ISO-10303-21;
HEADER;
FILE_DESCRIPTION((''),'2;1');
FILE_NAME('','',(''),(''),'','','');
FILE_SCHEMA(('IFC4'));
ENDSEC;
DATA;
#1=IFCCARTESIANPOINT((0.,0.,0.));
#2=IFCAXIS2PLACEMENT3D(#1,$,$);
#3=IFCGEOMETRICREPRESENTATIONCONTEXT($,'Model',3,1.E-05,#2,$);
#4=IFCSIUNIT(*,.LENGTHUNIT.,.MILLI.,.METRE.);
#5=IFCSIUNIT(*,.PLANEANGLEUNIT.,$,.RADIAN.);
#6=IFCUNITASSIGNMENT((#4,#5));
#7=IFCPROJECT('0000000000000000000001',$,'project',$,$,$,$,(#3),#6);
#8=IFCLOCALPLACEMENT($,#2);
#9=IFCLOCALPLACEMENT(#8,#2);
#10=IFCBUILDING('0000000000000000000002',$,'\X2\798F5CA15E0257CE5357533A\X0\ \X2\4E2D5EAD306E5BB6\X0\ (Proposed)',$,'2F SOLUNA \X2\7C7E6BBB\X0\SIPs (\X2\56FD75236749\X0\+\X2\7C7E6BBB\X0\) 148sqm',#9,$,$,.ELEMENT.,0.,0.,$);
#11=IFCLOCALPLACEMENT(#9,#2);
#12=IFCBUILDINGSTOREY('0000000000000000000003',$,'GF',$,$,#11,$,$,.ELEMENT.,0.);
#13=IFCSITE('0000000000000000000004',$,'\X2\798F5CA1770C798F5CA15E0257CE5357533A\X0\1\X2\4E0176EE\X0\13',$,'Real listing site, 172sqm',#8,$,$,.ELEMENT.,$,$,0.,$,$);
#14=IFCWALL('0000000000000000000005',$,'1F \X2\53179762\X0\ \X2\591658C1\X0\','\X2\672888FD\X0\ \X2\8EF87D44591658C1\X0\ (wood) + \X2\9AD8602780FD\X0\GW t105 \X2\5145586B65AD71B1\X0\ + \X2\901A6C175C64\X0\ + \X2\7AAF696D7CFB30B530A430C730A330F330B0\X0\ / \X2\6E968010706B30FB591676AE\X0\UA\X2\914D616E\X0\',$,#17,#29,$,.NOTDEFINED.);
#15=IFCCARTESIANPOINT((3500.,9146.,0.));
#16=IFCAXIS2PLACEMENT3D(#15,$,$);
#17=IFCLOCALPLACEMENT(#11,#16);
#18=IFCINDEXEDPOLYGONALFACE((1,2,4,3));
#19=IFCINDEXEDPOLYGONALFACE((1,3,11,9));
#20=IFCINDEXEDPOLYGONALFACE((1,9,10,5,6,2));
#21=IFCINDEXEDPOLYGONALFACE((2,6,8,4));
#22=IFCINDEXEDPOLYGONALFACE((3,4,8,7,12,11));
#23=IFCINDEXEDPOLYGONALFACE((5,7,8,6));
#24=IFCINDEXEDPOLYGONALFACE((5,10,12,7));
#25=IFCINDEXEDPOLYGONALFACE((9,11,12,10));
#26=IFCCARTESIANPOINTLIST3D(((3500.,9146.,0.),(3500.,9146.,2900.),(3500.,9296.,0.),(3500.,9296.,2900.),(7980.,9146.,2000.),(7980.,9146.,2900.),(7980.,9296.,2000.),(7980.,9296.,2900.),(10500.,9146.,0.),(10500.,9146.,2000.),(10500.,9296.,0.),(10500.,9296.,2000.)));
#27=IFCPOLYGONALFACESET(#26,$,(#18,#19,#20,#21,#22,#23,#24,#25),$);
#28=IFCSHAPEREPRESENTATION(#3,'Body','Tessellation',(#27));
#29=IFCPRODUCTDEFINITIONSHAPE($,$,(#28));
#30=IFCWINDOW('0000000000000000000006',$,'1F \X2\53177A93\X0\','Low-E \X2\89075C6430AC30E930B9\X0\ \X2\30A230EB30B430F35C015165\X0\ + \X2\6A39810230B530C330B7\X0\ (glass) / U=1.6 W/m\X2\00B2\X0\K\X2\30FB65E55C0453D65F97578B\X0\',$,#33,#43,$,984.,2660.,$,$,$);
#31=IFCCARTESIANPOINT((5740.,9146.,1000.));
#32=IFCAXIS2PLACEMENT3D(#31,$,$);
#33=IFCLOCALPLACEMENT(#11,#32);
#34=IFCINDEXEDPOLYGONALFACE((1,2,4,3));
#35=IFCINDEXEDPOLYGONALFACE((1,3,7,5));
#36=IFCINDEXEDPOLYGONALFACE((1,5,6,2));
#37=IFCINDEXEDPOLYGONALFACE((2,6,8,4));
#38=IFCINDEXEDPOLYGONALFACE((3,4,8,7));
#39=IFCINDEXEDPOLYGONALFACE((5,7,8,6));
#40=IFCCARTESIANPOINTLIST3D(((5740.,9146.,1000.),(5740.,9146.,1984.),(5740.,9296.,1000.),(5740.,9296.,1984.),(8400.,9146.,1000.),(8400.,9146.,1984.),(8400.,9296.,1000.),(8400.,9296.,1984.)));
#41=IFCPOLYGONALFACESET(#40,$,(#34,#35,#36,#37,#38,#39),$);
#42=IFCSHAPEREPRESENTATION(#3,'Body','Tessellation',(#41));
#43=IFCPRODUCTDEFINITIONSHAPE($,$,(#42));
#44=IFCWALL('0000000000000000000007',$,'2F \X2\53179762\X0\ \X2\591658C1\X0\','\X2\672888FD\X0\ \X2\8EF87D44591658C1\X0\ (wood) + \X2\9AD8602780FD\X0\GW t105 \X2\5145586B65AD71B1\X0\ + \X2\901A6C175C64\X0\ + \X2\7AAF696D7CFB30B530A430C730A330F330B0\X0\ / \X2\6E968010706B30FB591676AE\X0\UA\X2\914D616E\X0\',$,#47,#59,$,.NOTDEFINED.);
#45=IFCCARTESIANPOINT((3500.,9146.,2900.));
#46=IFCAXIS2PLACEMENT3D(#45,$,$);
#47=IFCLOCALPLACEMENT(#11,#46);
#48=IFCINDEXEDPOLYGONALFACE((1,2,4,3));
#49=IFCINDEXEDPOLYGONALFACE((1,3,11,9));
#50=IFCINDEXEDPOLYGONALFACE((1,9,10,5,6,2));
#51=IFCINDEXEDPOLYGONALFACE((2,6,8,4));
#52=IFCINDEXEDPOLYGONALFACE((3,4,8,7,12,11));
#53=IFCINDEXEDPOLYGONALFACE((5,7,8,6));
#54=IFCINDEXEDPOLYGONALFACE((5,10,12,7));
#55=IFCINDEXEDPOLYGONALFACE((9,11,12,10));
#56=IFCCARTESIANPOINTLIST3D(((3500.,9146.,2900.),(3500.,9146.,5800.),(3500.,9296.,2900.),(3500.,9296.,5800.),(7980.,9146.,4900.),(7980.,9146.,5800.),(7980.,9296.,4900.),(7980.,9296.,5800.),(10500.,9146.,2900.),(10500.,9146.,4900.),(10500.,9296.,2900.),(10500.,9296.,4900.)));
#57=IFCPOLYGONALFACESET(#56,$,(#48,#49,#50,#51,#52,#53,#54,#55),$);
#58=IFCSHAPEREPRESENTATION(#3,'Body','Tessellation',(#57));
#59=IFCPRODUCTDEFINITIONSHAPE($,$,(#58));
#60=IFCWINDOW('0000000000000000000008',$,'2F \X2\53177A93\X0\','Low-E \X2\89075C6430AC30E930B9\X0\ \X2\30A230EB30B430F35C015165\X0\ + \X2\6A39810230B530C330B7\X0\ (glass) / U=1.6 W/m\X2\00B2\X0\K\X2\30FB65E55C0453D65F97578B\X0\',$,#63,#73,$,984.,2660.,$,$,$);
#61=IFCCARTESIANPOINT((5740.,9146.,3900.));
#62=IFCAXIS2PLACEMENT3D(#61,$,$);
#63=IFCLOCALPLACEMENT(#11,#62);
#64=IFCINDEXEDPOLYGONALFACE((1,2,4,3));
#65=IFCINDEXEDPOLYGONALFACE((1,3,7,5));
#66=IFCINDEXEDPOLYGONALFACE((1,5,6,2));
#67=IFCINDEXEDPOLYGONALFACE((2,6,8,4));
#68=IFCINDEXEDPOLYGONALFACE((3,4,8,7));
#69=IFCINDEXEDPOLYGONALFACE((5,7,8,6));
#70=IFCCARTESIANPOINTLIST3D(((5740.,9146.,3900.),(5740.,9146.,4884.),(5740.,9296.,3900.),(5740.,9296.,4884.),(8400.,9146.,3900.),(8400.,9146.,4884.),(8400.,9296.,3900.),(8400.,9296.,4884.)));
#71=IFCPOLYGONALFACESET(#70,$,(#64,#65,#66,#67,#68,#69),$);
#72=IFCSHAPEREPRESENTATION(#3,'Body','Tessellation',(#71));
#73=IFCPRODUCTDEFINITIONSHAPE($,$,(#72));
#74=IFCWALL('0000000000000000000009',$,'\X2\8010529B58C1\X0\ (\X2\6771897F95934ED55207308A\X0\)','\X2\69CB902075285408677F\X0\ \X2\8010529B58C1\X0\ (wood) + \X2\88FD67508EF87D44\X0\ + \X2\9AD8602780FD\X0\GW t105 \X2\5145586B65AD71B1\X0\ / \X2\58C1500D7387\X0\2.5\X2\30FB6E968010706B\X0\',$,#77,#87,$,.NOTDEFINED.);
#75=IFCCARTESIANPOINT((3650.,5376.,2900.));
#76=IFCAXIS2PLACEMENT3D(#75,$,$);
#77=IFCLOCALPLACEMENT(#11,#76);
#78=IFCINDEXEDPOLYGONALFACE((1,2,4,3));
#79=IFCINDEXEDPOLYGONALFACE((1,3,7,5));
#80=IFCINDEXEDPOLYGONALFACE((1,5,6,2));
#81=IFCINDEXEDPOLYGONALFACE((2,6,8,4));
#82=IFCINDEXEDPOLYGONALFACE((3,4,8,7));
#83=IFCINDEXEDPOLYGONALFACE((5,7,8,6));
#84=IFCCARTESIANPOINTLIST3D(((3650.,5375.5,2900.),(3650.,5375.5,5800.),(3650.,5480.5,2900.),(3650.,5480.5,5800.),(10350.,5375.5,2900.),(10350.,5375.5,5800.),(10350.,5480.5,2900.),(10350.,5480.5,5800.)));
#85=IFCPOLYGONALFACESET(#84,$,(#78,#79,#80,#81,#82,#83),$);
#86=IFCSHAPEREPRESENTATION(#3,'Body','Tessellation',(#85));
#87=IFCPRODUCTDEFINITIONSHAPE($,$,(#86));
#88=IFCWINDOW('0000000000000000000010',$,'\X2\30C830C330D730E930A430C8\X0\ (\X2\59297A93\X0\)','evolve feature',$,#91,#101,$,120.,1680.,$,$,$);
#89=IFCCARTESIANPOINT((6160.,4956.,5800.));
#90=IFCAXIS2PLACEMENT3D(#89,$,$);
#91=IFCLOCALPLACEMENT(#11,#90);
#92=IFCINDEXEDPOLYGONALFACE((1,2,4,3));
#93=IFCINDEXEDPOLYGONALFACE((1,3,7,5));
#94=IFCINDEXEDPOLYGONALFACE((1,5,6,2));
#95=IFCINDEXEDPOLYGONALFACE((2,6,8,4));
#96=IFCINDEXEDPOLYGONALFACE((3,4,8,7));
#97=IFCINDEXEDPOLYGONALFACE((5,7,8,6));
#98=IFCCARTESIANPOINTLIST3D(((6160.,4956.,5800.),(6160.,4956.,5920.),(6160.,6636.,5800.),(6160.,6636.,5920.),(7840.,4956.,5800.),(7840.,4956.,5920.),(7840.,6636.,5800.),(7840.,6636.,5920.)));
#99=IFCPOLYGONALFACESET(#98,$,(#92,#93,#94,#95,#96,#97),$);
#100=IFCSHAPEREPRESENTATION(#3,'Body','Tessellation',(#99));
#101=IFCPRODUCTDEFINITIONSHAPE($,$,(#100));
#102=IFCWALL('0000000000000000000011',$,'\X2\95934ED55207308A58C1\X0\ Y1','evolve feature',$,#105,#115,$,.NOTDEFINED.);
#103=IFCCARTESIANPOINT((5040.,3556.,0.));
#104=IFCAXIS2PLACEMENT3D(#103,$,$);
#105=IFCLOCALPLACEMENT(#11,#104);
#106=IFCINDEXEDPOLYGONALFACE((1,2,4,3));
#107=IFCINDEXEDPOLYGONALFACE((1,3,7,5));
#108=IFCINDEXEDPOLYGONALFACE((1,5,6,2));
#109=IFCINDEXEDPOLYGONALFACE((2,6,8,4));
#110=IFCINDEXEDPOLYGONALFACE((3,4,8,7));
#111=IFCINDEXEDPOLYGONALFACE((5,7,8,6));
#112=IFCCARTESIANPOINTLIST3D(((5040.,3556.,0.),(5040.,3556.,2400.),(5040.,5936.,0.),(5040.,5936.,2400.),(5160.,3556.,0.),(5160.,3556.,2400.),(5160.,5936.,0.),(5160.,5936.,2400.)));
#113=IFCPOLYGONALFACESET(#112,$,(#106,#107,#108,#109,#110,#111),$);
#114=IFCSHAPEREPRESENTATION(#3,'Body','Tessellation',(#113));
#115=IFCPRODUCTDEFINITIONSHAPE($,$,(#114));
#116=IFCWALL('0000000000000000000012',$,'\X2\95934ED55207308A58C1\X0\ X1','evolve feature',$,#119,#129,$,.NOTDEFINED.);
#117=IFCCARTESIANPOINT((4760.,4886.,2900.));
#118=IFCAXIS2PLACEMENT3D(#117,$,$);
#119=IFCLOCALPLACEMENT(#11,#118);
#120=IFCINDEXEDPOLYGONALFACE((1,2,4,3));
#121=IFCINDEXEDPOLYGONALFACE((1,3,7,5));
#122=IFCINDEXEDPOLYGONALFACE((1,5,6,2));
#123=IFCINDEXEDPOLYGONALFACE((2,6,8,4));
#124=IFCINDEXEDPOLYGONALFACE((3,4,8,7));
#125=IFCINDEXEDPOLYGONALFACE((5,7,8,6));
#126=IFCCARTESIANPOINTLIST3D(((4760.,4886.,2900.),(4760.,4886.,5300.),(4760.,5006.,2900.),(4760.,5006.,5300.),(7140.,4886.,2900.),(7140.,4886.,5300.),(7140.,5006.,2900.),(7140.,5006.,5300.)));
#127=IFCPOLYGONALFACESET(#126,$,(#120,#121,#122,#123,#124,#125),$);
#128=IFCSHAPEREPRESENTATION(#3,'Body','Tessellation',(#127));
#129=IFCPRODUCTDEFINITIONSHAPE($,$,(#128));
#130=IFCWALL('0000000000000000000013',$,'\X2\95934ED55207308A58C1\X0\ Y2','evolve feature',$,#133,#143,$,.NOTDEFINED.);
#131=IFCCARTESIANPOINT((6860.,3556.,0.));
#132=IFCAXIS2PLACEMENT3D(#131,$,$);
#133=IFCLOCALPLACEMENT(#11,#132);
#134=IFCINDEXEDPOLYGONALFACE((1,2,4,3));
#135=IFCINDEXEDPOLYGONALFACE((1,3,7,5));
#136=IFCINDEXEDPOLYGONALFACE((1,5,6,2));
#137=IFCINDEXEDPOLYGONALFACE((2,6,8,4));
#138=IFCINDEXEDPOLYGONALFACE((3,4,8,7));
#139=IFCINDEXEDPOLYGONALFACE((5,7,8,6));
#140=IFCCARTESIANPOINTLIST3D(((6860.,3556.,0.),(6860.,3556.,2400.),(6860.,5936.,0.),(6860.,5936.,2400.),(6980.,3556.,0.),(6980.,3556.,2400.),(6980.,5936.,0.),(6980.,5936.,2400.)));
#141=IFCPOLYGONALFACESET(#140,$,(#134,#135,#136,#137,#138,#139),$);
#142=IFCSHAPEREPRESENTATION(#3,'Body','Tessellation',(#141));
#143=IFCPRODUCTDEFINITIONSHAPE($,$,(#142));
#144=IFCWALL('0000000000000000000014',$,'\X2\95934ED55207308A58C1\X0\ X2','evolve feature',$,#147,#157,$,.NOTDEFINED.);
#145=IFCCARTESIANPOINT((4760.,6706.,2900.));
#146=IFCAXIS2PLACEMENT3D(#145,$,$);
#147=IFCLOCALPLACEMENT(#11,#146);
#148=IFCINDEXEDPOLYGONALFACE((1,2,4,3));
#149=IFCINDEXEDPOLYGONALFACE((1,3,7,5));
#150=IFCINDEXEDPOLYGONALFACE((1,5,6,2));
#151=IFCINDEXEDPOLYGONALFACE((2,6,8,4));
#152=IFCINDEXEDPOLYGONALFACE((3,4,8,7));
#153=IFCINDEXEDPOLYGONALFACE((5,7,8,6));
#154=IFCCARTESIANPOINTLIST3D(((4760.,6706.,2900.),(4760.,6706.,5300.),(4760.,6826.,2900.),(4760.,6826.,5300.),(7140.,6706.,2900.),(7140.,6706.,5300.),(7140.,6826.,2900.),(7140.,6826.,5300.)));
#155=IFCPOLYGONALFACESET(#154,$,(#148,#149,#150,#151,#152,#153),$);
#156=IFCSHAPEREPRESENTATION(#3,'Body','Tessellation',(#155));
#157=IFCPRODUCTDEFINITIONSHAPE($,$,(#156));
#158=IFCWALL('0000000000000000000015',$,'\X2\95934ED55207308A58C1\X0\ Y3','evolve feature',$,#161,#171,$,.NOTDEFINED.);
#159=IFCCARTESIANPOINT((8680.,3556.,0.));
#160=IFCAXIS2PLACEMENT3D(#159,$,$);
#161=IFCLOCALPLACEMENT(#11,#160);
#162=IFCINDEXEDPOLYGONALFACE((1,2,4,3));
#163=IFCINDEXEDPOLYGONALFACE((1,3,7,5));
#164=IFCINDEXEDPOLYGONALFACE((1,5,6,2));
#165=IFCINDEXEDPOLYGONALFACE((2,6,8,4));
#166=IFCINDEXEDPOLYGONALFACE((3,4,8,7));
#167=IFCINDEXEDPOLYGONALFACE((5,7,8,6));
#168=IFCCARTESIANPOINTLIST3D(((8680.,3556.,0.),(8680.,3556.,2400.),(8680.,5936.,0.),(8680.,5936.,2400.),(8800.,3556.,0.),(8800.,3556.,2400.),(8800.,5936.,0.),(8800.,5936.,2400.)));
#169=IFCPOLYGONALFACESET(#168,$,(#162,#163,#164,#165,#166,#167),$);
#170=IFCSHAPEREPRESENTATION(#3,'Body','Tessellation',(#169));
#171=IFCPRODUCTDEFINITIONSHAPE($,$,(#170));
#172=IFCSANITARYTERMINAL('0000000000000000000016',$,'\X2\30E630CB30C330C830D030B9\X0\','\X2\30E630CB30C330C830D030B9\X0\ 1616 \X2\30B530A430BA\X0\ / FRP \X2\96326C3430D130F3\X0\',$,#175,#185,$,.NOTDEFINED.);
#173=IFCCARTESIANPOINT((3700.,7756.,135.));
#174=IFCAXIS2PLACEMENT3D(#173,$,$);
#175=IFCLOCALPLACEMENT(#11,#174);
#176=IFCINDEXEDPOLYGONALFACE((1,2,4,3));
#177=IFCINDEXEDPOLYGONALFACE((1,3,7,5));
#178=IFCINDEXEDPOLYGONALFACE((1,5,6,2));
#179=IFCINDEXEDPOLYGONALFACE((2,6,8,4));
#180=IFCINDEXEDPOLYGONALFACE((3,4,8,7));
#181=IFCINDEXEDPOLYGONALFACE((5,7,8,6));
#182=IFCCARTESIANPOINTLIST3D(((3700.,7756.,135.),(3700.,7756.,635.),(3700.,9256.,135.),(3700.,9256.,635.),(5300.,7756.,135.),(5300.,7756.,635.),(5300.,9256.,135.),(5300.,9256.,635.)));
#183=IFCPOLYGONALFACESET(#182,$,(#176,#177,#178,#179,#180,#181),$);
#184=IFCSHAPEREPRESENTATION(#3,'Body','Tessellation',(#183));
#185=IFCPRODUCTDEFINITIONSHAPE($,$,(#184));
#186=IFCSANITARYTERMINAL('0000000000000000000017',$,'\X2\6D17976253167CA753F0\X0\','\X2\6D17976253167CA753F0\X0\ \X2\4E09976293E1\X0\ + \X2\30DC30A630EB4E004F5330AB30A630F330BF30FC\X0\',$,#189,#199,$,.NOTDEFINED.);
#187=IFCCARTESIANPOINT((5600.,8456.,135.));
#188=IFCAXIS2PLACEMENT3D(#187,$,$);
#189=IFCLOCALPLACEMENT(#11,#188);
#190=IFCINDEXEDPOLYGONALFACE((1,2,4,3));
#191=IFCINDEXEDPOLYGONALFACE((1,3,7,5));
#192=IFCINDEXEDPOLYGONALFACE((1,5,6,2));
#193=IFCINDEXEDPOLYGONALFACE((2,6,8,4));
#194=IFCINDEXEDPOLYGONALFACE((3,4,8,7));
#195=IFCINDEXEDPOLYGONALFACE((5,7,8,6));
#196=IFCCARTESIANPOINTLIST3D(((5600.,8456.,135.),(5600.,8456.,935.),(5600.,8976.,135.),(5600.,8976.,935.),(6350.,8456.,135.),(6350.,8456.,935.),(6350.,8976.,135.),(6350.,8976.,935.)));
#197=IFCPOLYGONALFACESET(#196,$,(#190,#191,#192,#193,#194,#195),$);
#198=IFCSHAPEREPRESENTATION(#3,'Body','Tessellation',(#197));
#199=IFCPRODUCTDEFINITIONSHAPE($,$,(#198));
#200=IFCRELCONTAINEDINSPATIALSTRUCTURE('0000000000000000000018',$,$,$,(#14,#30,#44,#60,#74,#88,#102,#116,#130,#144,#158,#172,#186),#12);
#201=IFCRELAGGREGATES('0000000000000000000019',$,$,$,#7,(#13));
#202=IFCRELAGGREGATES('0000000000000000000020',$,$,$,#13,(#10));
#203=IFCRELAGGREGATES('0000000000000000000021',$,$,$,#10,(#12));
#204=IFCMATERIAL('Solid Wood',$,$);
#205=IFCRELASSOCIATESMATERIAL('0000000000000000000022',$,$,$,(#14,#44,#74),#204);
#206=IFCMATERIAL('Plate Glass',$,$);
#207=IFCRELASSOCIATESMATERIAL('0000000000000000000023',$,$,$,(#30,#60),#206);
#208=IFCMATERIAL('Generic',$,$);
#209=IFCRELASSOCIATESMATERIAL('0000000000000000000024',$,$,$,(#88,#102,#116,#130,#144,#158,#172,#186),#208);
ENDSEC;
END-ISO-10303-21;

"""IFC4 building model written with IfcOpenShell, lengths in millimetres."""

from ifc_helpers import new_model, si_unit, frame, frame_2d, origin, place, context, project, spatial, rectangle, extrude, material, element, fill, save


model = new_model("IFC4")

# Units and contexts
model_context = context("Model", 3, precision=1e-05, world=origin())
ifc_project = project(units=[si_unit("LENGTHUNIT", "METRE", prefix="MILLI"), si_unit("PLANEANGLEUNIT", "RADIAN")], contexts=[model_context])

# Site, building, storey
site_placement = place(None, origin())
site = spatial("IfcSite", under=ifc_project, at=site_placement, Name="福岡県福岡市城南区1丁目13", ObjectType="Real listing site, 172sqm", CompositionType="ELEMENT", RefElevation=0.0)
building_placement = place(site_placement, origin())
building = spatial("IfcBuilding", under=site, at=building_placement, Name="福岡市城南区 中庭の家 (Proposed)", ObjectType="2F SOLUNA 籾殻SIPs (国産杉+籾殻) 148sqm", CompositionType="ELEMENT", ElevationOfRefHeight=0.0, ElevationOfTerrain=0.0)
storey_placement = place(building_placement, origin())
storey = spatial("IfcBuildingStorey", under=building, at=storey_placement, Name="GF", CompositionType="ELEMENT", Elevation=0.0)

# Wall, opening, window
ifc_material_1 = material(Name="Solid Wood")
wall_1_placement = place(storey_placement, frame((3500.0, 9146.0, 0.0)))
wall_1 = element("IfcWall", 1, at=wall_1_placement, inside=storey, material=ifc_material_1, Name="1F 北面 外壁", Description="木製 軸組外壁 (wood) + 高性能GW t105 充填断熱 + 通気層 + 窯業系サイディング / 準耐火・外皮UA配慮", PredefinedType="NOTDEFINED", context=model_context, shape_type="SweptSolid", body=[
    extrude(rectangle(XDim=7000.0, YDim=150.0, at=frame_2d((3500.0, 75.0))), frame((3500.0, 9146.0, 0.0)), (0.0, 0.0, 1.0), 2900.0),
])
opening_1_placement = place(storey_placement, frame((5740.0, 9146.0, 1000.0)))
opening_1 = element("IfcOpeningElement", 2, at=opening_1_placement, cuts=wall_1, PredefinedType="NOTDEFINED", context=model_context, shape_type="SweptSolid", body=[
    extrude(rectangle(XDim=2660.0, YDim=150.0, at=frame_2d((1330.0, 75.0))), frame((5740.0, 9146.0, 1000.0)), (0.0, 0.0, 1.0), 984.0),
])
ifc_material_2 = material(Name="Plate Glass")
window_1_placement = place(storey_placement, frame((5740.0, 9146.0, 1000.0)))
window_1 = element("IfcWindow", 3, at=window_1_placement, inside=storey, material=ifc_material_2, Name="1F 北窓", Description="Low-E 複層ガラス アルゴン封入 + 樹脂サッシ (glass) / U=1.6 W/m²K・日射取得型", OverallHeight=984.0, OverallWidth=2660.0, context=model_context, shape_type="SweptSolid", body=[
    extrude(rectangle(XDim=2660.0, YDim=150.0, at=frame_2d((1330.0, 75.0))), frame((5740.0, 9146.0, 1000.0)), (0.0, 0.0, 1.0), 984.0),
])
fill(opening_1, window_1)

# Wall, opening, window
wall_2_placement = place(storey_placement, frame((3500.0, 9146.0, 2900.0)))
wall_2 = element("IfcWall", 4, at=wall_2_placement, inside=storey, material=ifc_material_1, Name="2F 北面 外壁", Description="木製 軸組外壁 (wood) + 高性能GW t105 充填断熱 + 通気層 + 窯業系サイディング / 準耐火・外皮UA配慮", PredefinedType="NOTDEFINED", context=model_context, shape_type="SweptSolid", body=[
    extrude(rectangle(XDim=7000.0, YDim=150.0, at=frame_2d((3500.0, 75.0))), frame((3500.0, 9146.0, 2900.0)), (0.0, 0.0, 1.0), 2900.0),
])
opening_2_placement = place(storey_placement, frame((5740.0, 9146.0, 3900.0)))
opening_2 = element("IfcOpeningElement", 5, at=opening_2_placement, cuts=wall_2, PredefinedType="NOTDEFINED", context=model_context, shape_type="SweptSolid", body=[
    extrude(rectangle(XDim=2660.0, YDim=150.0, at=frame_2d((1330.0, 75.0))), frame((5740.0, 9146.0, 3900.0)), (0.0, 0.0, 1.0), 984.0),
])
window_2_placement = place(storey_placement, frame((5740.0, 9146.0, 3900.0)))
window_2 = element("IfcWindow", 6, at=window_2_placement, inside=storey, material=ifc_material_2, Name="2F 北窓", Description="Low-E 複層ガラス アルゴン封入 + 樹脂サッシ (glass) / U=1.6 W/m²K・日射取得型", OverallHeight=984.0, OverallWidth=2660.0, context=model_context, shape_type="SweptSolid", body=[
    extrude(rectangle(XDim=2660.0, YDim=150.0, at=frame_2d((1330.0, 75.0))), frame((5740.0, 9146.0, 3900.0)), (0.0, 0.0, 1.0), 984.0),
])
fill(opening_2, window_2)

# Wall
wall_3_placement = place(storey_placement, frame((3650.0, 5376.0, 2900.0)))
element("IfcWall", 7, at=wall_3_placement, inside=storey, material=ifc_material_1, Name="耐力壁 (東西間仕切り)", Description="構造用合板 耐力壁 (wood) + 製材軸組 + 高性能GW t105 充填断熱 / 壁倍率2.5・準耐火", PredefinedType="NOTDEFINED", context=model_context, shape_type="SweptSolid", body=[
    extrude(rectangle(XDim=6700.0, YDim=105.0, at=frame_2d((3350.0, 52.0))), frame((3650.0, 5376.0, 2900.0)), (0.0, 0.0, 1.0), 2900.0),
])

# Window
ifc_material_3 = material(Name="Generic")
window_3_placement = place(storey_placement, frame((6160.0, 4956.0, 5800.0)))
element("IfcWindow", 8, at=window_3_placement, inside=storey, material=ifc_material_3, Name="トップライト (天窓)", Description="evolve feature", OverallHeight=120.0, OverallWidth=1680.0, context=model_context, shape_type="SweptSolid", body=[
    extrude(rectangle(XDim=1680.0, YDim=1680.0, at=frame_2d((840.0, 840.0))), frame((6160.0, 4956.0, 5800.0)), (0.0, 0.0, 1.0), 120.0),
])

# Walls
wall_4_placement = place(storey_placement, frame((5040.0, 3556.0, 0.0)))
element("IfcWall", 9, at=wall_4_placement, inside=storey, material=ifc_material_3, Name="間仕切り壁 Y1", Description="evolve feature", PredefinedType="NOTDEFINED", context=model_context, shape_type="SweptSolid", body=[
    extrude(rectangle(XDim=120.0, YDim=2380.0, at=frame_2d((60.0, 1190.0))), frame((5040.0, 3556.0, 0.0)), (0.0, 0.0, 1.0), 2400.0),
])
wall_5_placement = place(storey_placement, frame((4760.0, 4886.0, 2900.0)))
element("IfcWall", 10, at=wall_5_placement, inside=storey, material=ifc_material_3, Name="間仕切り壁 X1", Description="evolve feature", PredefinedType="NOTDEFINED", context=model_context, shape_type="SweptSolid", body=[
    extrude(rectangle(XDim=2380.0, YDim=120.0, at=frame_2d((1190.0, 60.0))), frame((4760.0, 4886.0, 2900.0)), (0.0, 0.0, 1.0), 2400.0),
])
wall_6_placement = place(storey_placement, frame((6860.0, 3556.0, 0.0)))
element("IfcWall", 11, at=wall_6_placement, inside=storey, material=ifc_material_3, Name="間仕切り壁 Y2", Description="evolve feature", PredefinedType="NOTDEFINED", context=model_context, shape_type="SweptSolid", body=[
    extrude(rectangle(XDim=120.0, YDim=2380.0, at=frame_2d((60.0, 1190.0))), frame((6860.0, 3556.0, 0.0)), (0.0, 0.0, 1.0), 2400.0),
])
wall_7_placement = place(storey_placement, frame((4760.0, 6706.0, 2900.0)))
element("IfcWall", 12, at=wall_7_placement, inside=storey, material=ifc_material_3, Name="間仕切り壁 X2", Description="evolve feature", PredefinedType="NOTDEFINED", context=model_context, shape_type="SweptSolid", body=[
    extrude(rectangle(XDim=2380.0, YDim=120.0, at=frame_2d((1190.0, 60.0))), frame((4760.0, 6706.0, 2900.0)), (0.0, 0.0, 1.0), 2400.0),
])
wall_8_placement = place(storey_placement, frame((8680.0, 3556.0, 0.0)))
element("IfcWall", 13, at=wall_8_placement, inside=storey, material=ifc_material_3, Name="間仕切り壁 Y3", Description="evolve feature", PredefinedType="NOTDEFINED", context=model_context, shape_type="SweptSolid", body=[
    extrude(rectangle(XDim=120.0, YDim=2380.0, at=frame_2d((60.0, 1190.0))), frame((8680.0, 3556.0, 0.0)), (0.0, 0.0, 1.0), 2400.0),
])

# Sanitary terminals
sanitary_terminal_1_placement = place(storey_placement, frame((3700.0, 7756.0, 135.0)))
element("IfcSanitaryTerminal", 14, at=sanitary_terminal_1_placement, inside=storey, material=ifc_material_3, Name="ユニットバス", Description="ユニットバス 1616 サイズ / FRP 防水パン", PredefinedType="NOTDEFINED", context=model_context, shape_type="SweptSolid", body=[
    extrude(rectangle(XDim=1600.0, YDim=1500.0, at=frame_2d((800.0, 750.0))), frame((3700.0, 7756.0, 135.0)), (0.0, 0.0, 1.0), 500.0),
])
sanitary_terminal_2_placement = place(storey_placement, frame((5600.0, 8456.0, 135.0)))
element("IfcSanitaryTerminal", 15, at=sanitary_terminal_2_placement, inside=storey, material=ifc_material_3, Name="洗面化粧台", Description="洗面化粧台 三面鏡 + ボウル一体カウンター", PredefinedType="NOTDEFINED", context=model_context, shape_type="SweptSolid", body=[
    extrude(rectangle(XDim=750.0, YDim=520.0, at=frame_2d((375.0, 260.0))), frame((5600.0, 8456.0, 135.0)), (0.0, 0.0, 1.0), 800.0),
])

save(model, "model.ifc")
